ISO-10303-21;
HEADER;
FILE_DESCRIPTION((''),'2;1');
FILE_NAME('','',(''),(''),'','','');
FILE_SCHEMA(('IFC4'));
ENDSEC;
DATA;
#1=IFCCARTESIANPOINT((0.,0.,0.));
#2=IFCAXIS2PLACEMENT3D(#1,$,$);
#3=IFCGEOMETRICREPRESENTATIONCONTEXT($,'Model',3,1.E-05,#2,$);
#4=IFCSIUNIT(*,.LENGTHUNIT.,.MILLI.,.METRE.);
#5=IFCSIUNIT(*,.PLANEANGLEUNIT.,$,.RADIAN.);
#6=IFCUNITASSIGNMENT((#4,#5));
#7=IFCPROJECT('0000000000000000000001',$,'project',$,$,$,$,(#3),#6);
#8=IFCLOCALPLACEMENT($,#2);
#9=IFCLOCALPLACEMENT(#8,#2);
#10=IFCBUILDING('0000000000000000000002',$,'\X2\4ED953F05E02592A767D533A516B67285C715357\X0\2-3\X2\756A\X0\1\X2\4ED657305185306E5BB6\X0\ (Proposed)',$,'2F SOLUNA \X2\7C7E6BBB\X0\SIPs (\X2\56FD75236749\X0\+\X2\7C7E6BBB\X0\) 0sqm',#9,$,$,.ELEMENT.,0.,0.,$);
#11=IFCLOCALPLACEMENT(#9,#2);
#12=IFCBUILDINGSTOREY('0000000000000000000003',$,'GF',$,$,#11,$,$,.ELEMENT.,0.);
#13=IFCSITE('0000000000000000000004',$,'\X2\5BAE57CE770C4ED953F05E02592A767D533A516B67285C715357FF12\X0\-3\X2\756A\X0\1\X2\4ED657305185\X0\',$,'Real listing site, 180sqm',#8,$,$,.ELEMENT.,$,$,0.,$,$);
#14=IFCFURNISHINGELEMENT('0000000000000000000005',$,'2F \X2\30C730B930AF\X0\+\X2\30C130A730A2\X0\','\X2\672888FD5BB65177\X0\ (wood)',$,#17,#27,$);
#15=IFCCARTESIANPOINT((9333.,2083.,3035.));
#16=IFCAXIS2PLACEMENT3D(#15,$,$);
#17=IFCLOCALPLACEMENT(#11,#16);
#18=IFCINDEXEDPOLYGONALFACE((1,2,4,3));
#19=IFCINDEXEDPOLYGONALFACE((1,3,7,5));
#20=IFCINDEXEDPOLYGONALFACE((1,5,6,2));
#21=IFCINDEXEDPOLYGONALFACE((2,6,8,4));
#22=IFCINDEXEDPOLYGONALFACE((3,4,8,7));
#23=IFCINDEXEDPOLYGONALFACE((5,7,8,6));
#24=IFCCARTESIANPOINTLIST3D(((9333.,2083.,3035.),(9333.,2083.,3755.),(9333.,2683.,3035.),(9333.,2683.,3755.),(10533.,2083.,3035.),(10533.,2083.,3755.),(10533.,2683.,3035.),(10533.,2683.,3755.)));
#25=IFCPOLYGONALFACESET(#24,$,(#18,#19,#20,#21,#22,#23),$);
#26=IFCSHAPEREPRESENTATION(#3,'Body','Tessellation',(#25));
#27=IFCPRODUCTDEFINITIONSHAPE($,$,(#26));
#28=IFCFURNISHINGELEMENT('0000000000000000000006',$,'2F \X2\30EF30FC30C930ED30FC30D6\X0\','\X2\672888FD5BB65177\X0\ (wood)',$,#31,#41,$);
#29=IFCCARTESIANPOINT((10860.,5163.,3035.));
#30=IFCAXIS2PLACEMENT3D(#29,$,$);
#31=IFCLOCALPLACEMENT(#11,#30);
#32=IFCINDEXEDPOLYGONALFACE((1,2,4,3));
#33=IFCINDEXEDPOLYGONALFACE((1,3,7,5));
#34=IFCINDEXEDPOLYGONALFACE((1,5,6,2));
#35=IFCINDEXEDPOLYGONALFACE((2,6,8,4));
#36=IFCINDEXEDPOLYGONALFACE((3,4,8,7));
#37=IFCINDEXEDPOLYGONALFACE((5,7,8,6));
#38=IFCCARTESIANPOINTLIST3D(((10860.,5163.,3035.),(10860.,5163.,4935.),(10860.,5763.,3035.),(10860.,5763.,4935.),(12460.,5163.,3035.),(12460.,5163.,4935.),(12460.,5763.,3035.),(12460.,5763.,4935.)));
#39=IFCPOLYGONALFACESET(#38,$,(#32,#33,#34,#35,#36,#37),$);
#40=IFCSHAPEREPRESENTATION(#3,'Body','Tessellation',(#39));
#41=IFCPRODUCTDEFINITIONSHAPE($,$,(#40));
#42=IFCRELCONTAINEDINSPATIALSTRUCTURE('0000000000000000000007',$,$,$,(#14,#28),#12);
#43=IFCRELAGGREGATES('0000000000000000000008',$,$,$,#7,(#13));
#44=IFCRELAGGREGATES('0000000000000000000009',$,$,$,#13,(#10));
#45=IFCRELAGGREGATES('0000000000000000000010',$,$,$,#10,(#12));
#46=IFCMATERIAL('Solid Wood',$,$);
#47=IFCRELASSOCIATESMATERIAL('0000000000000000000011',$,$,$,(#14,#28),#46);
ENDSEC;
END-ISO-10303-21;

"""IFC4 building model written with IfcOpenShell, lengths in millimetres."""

from ifc_helpers import new_model, si_unit, frame, frame_2d, origin, place, context, project, spatial, rectangle, extrude, material, element, save


model = new_model("IFC4")

# Units and contexts
model_context = context("Model", 3, precision=1e-05, world=origin())
ifc_project = project(units=[si_unit("LENGTHUNIT", "METRE", prefix="MILLI"), si_unit("PLANEANGLEUNIT", "RADIAN")], contexts=[model_context])

# Site, building, storey
site_placement = place(None, origin())
site = spatial("IfcSite", under=ifc_project, at=site_placement, Name="宮城県仙台市太白区八木山南２-3番1他地内", ObjectType="Real listing site, 180sqm", CompositionType="ELEMENT", RefElevation=0.0)
building_placement = place(site_placement, origin())
building = spatial("IfcBuilding", under=site, at=building_placement, Name="仙台市太白区八木山南2-3番1他地内の家 (Proposed)", ObjectType="2F SOLUNA 籾殻SIPs (国産杉+籾殻) 0sqm", CompositionType="ELEMENT", ElevationOfRefHeight=0.0, ElevationOfTerrain=0.0)
storey_placement = place(building_placement, origin())
storey = spatial("IfcBuildingStorey", under=building, at=storey_placement, Name="GF", CompositionType="ELEMENT", Elevation=0.0)

# Shared definitions
ifc_material_1 = material(Name="Solid Wood")

# Furnishing elements
furnishing_1_placement = place(storey_placement, frame((9333.0, 2083.0, 3035.0)))
element("IfcFurnishingElement", 1, at=furnishing_1_placement, inside=storey, material=ifc_material_1, Name="2F デスク+チェア", Description="木製家具 (wood)", context=model_context, shape_type="SweptSolid", body=[
    extrude(rectangle(XDim=1200.0, YDim=600.0, at=frame_2d((600.0, 300.0))), frame((9333.0, 2083.0, 3035.0)), (0.0, 0.0, 1.0), 720.0),
])
furnishing_2_placement = place(storey_placement, frame((10860.0, 5163.0, 3035.0)))
element("IfcFurnishingElement", 2, at=furnishing_2_placement, inside=storey, material=ifc_material_1, Name="2F ワードローブ", Description="木製家具 (wood)", context=model_context, shape_type="SweptSolid", body=[
    extrude(rectangle(XDim=1600.0, YDim=600.0, at=frame_2d((800.0, 300.0))), frame((10860.0, 5163.0, 3035.0)), (0.0, 0.0, 1.0), 1900.0),
])

save(model, "model.ifc")
